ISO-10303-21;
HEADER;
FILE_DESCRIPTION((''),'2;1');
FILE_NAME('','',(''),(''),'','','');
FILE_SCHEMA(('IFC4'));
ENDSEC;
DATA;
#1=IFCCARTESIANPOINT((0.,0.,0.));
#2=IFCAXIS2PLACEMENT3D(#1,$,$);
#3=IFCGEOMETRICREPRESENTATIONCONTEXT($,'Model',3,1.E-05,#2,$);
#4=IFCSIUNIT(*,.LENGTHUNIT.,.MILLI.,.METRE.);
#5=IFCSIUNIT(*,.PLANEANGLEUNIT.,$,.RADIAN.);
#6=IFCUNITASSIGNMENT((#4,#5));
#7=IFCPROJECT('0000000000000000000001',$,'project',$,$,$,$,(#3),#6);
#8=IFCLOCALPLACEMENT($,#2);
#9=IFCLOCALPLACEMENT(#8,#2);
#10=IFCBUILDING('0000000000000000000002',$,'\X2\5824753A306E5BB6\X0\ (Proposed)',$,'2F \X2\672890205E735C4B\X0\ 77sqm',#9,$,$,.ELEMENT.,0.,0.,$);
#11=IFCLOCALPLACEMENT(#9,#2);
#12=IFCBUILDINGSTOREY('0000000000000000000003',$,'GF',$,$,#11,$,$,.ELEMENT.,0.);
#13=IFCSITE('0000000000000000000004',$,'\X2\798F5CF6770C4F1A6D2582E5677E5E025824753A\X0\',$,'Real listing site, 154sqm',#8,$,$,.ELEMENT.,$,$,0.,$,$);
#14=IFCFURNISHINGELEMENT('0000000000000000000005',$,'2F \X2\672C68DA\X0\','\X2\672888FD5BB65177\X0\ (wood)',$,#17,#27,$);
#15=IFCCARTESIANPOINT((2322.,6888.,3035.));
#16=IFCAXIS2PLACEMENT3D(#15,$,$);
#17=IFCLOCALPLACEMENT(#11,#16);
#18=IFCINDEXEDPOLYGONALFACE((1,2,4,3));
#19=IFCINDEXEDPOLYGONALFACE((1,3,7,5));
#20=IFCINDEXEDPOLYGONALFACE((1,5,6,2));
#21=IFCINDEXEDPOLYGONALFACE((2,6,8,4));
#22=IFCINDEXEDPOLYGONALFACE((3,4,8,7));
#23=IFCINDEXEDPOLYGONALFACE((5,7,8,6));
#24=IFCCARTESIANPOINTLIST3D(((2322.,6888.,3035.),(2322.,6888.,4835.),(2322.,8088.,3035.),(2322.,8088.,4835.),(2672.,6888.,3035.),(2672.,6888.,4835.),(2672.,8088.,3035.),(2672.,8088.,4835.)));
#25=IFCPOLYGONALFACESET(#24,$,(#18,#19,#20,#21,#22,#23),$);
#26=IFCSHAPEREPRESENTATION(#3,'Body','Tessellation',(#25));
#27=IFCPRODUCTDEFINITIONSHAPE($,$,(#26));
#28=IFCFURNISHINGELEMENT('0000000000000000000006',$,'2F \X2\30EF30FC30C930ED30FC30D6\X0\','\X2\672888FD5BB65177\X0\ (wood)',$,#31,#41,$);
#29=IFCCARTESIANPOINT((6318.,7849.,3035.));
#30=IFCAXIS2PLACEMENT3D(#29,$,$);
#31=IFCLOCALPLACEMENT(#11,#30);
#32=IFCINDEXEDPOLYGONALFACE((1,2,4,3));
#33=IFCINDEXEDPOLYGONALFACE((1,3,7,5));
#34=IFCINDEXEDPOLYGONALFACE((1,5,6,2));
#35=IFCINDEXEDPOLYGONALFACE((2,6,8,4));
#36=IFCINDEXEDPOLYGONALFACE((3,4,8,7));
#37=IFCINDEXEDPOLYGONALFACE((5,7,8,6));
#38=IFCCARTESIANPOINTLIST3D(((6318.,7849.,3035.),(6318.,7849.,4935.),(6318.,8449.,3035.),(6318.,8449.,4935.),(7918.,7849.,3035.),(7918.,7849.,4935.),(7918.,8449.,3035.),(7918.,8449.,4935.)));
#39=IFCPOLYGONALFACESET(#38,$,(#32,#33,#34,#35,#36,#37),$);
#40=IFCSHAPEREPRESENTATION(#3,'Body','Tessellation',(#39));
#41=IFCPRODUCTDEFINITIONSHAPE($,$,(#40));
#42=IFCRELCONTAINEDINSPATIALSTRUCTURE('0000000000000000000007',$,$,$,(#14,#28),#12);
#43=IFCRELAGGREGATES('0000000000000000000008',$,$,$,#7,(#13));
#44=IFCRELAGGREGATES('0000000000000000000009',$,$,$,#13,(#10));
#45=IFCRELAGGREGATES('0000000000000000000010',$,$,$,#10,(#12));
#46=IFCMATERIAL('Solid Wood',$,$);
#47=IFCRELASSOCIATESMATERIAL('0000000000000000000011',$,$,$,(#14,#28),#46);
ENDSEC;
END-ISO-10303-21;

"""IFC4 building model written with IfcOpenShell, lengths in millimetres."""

from ifc_helpers import new_model, si_unit, frame, frame_2d, origin, place, context, project, spatial, rectangle, extrude, material, element, save


model = new_model("IFC4")

# Units and contexts
model_context = context("Model", 3, precision=1e-05, world=origin())
ifc_project = project(units=[si_unit("LENGTHUNIT", "METRE", prefix="MILLI"), si_unit("PLANEANGLEUNIT", "RADIAN")], contexts=[model_context])

# Site, building, storey
site_placement = place(None, origin())
site = spatial("IfcSite", under=ifc_project, at=site_placement, Name="福島県会津若松市堤町", ObjectType="Real listing site, 154sqm", CompositionType="ELEMENT", RefElevation=0.0)
building_placement = place(site_placement, origin())
building = spatial("IfcBuilding", under=site, at=building_placement, Name="堤町の家 (Proposed)", ObjectType="2F 木造平屋 77sqm", CompositionType="ELEMENT", ElevationOfRefHeight=0.0, ElevationOfTerrain=0.0)
storey_placement = place(building_placement, origin())
storey = spatial("IfcBuildingStorey", under=building, at=storey_placement, Name="GF", CompositionType="ELEMENT", Elevation=0.0)

# Shared definitions
ifc_material_1 = material(Name="Solid Wood")

# Furnishing elements
furnishing_1_placement = place(storey_placement, frame((2322.0, 6888.0, 3035.0)))
element("IfcFurnishingElement", 1, at=furnishing_1_placement, inside=storey, material=ifc_material_1, Name="2F 本棚", Description="木製家具 (wood)", context=model_context, shape_type="SweptSolid", body=[
    extrude(rectangle(XDim=350.0, YDim=1200.0, at=frame_2d((175.0, 600.0))), frame((2322.0, 6888.0, 3035.0)), (0.0, 0.0, 1.0), 1800.0),
])
furnishing_2_placement = place(storey_placement, frame((6318.0, 7849.0, 3035.0)))
element("IfcFurnishingElement", 2, at=furnishing_2_placement, inside=storey, material=ifc_material_1, Name="2F ワードローブ", Description="木製家具 (wood)", context=model_context, shape_type="SweptSolid", body=[
    extrude(rectangle(XDim=1600.0, YDim=600.0, at=frame_2d((800.0, 300.0))), frame((6318.0, 7849.0, 3035.0)), (0.0, 0.0, 1.0), 1900.0),
])

save(model, "model.ifc")
